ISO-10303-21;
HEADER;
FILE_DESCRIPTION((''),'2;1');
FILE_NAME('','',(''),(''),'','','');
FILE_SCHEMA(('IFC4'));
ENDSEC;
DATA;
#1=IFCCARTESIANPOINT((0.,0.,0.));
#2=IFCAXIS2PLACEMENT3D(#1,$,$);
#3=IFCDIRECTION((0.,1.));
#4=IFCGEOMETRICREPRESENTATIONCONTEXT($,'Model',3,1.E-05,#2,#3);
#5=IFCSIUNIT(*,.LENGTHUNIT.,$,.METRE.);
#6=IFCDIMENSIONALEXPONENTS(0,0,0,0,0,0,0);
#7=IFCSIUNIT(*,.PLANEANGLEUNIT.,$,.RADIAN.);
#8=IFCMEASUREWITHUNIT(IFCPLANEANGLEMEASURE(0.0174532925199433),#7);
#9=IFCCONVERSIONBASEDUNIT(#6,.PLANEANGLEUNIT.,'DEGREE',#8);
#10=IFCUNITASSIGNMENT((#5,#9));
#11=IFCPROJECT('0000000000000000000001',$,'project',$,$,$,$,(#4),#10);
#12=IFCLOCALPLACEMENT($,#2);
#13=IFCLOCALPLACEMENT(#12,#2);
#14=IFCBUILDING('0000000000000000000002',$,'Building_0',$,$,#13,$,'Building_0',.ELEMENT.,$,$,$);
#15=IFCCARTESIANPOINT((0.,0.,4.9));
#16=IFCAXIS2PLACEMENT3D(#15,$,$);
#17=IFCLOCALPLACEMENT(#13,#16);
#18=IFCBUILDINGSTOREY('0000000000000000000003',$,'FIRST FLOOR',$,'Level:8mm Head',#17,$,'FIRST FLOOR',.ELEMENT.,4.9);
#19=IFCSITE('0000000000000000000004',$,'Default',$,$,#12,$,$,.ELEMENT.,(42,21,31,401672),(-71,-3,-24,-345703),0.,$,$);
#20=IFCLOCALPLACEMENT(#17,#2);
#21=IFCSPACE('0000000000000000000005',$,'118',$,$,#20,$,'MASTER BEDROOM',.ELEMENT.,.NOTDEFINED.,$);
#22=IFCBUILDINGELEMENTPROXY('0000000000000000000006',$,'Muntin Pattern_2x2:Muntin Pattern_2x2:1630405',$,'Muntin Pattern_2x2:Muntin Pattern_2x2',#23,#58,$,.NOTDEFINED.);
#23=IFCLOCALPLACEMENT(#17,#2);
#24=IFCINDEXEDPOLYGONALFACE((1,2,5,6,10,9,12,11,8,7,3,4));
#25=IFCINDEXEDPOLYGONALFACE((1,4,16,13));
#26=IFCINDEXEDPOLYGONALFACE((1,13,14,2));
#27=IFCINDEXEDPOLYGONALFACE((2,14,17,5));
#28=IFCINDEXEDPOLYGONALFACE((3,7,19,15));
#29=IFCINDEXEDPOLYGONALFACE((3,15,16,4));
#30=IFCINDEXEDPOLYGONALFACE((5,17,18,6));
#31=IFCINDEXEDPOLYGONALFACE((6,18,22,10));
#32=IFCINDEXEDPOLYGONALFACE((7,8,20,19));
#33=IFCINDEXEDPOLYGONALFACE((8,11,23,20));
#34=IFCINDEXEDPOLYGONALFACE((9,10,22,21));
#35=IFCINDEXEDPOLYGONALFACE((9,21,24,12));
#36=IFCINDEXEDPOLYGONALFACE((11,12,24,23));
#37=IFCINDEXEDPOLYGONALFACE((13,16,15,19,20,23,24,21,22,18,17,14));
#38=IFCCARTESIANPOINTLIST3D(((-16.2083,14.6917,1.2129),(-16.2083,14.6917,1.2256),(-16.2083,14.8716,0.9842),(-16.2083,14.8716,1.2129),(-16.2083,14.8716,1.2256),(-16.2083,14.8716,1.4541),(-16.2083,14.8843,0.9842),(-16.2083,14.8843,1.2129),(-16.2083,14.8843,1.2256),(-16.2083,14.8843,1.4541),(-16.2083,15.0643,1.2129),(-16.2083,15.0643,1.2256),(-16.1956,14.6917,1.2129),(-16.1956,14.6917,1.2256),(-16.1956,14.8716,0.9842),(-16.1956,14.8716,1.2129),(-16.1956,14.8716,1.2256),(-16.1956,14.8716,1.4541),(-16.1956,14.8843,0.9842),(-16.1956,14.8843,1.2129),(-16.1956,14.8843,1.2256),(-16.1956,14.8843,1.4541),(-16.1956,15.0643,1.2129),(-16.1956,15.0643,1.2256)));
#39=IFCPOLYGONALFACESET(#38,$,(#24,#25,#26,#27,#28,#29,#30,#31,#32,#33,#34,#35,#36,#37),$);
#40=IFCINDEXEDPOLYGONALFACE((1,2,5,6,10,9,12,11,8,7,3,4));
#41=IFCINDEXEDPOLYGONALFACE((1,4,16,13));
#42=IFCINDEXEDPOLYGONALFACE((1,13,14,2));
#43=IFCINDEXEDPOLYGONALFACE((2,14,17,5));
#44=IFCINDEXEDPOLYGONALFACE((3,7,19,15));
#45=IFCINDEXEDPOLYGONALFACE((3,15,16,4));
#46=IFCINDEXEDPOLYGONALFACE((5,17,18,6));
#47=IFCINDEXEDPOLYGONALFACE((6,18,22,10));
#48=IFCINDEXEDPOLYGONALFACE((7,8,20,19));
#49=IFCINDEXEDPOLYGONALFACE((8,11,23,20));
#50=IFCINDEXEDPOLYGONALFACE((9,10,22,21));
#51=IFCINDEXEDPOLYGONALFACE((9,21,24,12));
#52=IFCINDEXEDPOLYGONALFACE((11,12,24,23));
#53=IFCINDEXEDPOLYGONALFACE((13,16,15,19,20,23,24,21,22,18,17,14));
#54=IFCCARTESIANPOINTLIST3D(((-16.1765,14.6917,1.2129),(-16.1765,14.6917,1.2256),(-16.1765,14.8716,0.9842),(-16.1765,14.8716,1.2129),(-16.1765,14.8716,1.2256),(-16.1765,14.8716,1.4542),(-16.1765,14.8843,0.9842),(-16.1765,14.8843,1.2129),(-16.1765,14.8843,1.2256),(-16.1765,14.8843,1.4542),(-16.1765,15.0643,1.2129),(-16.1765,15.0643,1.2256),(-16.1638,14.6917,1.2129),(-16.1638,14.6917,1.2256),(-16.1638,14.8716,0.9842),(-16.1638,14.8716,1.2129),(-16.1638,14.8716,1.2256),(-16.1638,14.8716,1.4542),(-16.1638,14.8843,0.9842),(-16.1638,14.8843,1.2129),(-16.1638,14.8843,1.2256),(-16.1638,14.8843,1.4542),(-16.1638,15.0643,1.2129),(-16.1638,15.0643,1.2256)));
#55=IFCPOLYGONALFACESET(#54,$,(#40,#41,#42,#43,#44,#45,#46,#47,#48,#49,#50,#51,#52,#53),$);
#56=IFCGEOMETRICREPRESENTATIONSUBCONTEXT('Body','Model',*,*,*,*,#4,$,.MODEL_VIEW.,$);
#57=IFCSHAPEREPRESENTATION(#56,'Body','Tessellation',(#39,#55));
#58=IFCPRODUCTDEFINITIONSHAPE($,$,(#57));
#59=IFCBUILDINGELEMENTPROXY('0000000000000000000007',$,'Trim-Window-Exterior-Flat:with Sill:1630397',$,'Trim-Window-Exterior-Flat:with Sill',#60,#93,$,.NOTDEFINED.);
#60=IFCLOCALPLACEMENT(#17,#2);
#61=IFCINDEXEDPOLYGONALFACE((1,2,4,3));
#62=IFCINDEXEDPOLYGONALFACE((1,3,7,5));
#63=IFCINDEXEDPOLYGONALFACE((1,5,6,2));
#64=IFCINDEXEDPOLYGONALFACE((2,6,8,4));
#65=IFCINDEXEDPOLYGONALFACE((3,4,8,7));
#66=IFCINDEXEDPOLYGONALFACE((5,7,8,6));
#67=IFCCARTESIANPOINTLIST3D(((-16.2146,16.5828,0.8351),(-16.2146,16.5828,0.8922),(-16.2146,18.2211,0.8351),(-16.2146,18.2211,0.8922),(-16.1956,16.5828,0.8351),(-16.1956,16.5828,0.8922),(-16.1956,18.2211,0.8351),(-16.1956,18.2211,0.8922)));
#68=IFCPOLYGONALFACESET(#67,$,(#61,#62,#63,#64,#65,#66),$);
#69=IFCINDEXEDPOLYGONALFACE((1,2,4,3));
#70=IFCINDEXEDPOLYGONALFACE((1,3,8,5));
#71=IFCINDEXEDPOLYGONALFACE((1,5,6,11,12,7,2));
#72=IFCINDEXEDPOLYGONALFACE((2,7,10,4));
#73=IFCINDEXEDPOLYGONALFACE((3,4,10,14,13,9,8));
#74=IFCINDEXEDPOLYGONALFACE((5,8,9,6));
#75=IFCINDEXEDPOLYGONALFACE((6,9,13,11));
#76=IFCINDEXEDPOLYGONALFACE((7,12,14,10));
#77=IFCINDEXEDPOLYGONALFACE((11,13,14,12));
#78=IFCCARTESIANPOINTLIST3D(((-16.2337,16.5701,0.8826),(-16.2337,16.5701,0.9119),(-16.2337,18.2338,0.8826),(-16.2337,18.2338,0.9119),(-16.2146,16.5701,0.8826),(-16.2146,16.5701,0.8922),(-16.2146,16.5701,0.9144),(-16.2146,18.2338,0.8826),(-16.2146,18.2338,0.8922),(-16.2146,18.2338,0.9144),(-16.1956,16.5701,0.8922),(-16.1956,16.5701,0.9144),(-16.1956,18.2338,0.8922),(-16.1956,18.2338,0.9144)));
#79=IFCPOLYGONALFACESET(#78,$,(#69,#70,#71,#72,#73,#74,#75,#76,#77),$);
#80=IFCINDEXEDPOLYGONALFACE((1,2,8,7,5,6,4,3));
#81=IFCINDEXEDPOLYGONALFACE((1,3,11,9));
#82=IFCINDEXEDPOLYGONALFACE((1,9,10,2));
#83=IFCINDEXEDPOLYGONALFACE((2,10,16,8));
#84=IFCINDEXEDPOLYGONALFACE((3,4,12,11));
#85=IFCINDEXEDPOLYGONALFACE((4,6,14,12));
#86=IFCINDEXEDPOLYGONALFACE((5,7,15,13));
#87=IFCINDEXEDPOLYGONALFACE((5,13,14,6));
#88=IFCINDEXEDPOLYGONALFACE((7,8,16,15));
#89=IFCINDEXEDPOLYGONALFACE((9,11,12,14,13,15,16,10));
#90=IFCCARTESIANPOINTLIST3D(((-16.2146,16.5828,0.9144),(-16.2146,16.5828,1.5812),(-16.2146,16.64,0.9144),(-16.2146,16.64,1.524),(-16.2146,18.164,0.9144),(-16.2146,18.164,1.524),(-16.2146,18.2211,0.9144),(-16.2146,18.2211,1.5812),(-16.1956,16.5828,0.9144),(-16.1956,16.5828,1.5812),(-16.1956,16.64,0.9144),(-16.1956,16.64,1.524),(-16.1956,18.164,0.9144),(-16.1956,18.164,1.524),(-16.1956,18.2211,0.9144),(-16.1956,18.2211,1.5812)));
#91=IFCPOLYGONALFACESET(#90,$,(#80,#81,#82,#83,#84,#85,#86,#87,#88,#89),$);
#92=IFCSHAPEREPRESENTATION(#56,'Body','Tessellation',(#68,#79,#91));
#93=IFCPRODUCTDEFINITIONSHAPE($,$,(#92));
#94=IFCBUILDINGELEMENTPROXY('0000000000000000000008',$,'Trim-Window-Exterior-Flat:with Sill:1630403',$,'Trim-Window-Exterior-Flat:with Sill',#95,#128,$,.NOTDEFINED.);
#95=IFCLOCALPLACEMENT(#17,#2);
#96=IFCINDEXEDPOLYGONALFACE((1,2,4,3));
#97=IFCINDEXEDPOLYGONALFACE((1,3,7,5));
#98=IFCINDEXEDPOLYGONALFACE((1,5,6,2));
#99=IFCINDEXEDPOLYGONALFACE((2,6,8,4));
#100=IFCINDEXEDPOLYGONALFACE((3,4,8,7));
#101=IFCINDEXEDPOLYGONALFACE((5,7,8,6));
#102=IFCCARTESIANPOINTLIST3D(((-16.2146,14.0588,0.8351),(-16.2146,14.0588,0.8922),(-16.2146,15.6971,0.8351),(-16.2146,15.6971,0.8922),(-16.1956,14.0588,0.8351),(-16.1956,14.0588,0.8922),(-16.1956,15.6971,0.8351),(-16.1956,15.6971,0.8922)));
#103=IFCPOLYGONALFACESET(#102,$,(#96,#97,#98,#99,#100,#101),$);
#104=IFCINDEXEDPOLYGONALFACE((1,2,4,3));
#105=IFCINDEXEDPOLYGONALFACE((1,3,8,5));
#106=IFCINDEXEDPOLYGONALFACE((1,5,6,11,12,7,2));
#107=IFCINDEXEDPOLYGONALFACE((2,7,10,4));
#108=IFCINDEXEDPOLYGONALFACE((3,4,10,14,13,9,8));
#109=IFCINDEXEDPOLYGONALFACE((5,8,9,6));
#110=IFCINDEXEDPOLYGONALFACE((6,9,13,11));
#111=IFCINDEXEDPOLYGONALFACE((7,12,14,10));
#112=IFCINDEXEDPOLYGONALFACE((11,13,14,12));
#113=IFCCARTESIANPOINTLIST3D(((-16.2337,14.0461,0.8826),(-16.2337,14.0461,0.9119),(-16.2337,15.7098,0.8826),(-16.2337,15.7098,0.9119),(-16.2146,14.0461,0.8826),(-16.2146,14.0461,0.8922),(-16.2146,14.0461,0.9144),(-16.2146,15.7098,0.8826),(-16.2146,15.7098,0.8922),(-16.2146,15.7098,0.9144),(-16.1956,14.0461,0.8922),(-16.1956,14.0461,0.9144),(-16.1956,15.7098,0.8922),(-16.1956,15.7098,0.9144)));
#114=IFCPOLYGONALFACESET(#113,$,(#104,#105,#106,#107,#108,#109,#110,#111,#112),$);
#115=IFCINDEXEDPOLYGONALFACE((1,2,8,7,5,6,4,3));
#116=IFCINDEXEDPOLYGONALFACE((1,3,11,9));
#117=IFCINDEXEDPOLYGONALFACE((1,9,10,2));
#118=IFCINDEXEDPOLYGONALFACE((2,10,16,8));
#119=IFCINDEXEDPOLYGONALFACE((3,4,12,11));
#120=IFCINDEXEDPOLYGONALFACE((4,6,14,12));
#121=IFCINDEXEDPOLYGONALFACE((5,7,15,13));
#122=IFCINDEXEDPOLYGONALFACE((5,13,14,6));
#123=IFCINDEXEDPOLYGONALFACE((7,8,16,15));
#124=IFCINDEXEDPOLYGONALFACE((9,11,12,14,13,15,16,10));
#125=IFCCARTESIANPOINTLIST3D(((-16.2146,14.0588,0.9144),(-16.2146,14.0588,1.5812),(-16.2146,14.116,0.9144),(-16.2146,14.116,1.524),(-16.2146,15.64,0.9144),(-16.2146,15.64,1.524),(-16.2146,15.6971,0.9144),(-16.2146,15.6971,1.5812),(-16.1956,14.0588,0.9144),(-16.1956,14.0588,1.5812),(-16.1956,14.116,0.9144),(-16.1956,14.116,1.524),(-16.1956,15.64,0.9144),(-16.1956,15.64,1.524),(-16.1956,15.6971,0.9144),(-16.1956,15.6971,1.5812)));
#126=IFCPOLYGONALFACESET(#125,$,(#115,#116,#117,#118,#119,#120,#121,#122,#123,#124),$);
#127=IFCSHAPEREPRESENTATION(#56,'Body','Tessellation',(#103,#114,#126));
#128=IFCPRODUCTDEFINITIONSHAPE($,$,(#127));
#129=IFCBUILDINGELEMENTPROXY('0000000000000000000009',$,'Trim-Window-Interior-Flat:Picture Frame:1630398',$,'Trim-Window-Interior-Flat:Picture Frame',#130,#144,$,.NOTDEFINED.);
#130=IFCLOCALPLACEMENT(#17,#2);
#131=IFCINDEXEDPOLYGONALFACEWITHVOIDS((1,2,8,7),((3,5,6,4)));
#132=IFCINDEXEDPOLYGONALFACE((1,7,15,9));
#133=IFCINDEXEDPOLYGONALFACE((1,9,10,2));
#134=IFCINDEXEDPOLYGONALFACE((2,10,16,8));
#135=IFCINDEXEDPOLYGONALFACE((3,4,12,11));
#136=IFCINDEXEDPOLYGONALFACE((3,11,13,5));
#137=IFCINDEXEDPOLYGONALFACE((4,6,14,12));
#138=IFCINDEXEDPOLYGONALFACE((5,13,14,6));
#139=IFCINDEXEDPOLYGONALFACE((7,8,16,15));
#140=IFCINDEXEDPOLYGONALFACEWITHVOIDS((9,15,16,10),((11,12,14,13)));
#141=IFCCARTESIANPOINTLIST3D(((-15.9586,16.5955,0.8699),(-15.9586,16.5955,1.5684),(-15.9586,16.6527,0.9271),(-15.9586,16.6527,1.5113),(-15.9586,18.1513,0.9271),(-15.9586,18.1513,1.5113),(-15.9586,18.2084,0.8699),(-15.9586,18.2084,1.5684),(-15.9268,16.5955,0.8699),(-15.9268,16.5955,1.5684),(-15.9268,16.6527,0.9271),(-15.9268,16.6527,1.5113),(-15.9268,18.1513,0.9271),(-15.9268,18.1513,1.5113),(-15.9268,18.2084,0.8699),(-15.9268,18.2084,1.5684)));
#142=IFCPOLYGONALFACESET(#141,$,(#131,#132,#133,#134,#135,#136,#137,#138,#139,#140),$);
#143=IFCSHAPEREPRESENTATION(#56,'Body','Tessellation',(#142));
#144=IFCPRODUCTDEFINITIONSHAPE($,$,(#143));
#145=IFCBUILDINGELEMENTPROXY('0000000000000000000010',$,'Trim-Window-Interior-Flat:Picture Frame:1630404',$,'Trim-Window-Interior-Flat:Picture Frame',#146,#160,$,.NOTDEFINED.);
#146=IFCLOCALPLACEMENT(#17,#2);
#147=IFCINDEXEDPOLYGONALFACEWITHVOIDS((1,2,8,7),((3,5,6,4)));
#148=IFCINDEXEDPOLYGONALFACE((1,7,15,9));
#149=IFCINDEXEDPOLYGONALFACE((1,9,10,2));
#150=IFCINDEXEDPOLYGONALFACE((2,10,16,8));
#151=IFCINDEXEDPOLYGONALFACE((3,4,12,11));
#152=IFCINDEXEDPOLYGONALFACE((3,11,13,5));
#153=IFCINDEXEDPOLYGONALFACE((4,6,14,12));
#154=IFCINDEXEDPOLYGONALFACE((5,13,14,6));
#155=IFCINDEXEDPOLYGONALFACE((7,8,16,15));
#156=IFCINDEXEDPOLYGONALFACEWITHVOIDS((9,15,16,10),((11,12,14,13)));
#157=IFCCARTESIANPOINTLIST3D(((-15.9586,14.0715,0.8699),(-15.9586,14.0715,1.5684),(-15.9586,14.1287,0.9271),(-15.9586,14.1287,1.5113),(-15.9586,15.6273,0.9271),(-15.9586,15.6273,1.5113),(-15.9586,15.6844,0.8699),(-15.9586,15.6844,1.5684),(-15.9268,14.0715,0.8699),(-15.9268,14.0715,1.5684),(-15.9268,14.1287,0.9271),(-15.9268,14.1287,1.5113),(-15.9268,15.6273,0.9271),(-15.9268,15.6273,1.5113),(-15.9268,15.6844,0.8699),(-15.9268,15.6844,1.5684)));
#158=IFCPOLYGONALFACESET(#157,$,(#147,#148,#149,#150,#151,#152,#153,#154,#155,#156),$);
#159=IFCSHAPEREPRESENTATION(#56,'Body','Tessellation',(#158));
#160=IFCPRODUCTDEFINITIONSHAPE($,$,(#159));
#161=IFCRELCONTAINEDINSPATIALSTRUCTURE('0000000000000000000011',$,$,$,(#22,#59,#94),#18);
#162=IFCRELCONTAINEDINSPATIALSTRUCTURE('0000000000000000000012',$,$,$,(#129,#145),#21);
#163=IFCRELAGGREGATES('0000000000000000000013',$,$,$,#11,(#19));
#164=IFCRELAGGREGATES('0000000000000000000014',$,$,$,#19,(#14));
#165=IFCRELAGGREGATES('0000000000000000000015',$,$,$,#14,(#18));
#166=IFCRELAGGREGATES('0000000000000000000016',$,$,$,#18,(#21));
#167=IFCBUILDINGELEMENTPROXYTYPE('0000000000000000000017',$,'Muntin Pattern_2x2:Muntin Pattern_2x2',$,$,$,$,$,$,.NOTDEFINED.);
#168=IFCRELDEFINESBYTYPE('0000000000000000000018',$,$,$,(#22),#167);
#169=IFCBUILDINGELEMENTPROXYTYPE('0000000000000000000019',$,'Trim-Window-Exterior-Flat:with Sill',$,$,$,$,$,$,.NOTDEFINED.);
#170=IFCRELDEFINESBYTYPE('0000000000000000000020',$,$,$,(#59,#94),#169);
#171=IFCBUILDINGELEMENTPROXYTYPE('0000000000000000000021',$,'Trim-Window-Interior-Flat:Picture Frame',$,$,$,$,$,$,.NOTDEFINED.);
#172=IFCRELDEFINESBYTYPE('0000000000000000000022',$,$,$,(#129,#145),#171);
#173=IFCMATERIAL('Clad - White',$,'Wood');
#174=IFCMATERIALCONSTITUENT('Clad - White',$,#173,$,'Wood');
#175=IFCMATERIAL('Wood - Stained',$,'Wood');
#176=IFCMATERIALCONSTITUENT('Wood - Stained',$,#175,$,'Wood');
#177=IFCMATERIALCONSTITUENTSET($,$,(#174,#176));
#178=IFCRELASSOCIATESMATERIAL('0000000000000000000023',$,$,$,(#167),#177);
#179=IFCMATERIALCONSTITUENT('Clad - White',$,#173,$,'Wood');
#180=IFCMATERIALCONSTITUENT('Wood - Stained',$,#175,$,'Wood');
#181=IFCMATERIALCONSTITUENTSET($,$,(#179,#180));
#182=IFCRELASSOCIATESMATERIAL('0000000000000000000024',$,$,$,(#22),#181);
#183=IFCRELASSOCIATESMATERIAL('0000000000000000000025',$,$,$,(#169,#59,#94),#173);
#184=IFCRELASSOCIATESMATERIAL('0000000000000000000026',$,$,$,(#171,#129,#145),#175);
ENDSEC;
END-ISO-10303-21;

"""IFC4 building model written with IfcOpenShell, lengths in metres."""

from ifc_helpers import new_model, entity, si_unit, converted_unit, direction, frame, origin, place, context, subcontext, project, spatial, indexed_curve, outline, extrude, source, transform, mapped, material, constituent, constituent_set, type_object, type_shapes, element, save


model = new_model("IFC4")

# Units and contexts
model_context = context("Model", 3, precision=1e-05, world=origin(), true_north=direction((0.0, 1.0)))
body_context = subcontext(model_context, "Body", "Model", "MODEL_VIEW")
ifc_project = project(units=[si_unit("LENGTHUNIT", "METRE"), converted_unit("PLANEANGLEUNIT", "DEGREE", entity("IfcPlaneAngleMeasure", 0.0174532925199433), si_unit("PLANEANGLEUNIT", "RADIAN"), dimensions=[0, 0, 0, 0, 0, 0, 0])], contexts=[model_context])

# Site, building, storey
site_placement = place(None, origin())
site = spatial("IfcSite", under=ifc_project, at=site_placement, Name="Default", CompositionType="ELEMENT", RefLatitude=(42, 21, 31, 401672), RefLongitude=(-71, -3, -24, -345703), RefElevation=0.0)
building_placement = place(site_placement, origin())
building = spatial("IfcBuilding", under=site, at=building_placement, Name="Building_0", LongName="Building_0", CompositionType="ELEMENT")
storey_placement = place(building_placement, frame((0.0, 0.0, 4.9)))
storey = spatial("IfcBuildingStorey", under=building, at=storey_placement, Name="FIRST FLOOR", ObjectType="Level:8mm Head", LongName="FIRST FLOOR", CompositionType="ELEMENT", Elevation=4.9)

# Shared definitions
ifc_material_1 = material(Name="Clad - White", Category="Wood")

# Shared definitions
space_placement = place(storey_placement, origin())
space = spatial("IfcSpace", under=storey, at=space_placement, Name="118", LongName="MASTER BEDROOM", CompositionType="ELEMENT", PredefinedType="NOTDEFINED")

# Building element proxies
ifc_material_2 = material(Name="Wood - Stained", Category="Wood")
ifc_constituent_1 = constituent(ifc_material_1, Name="Clad - White", Category="Wood")
ifc_constituent_2 = constituent(ifc_material_2, Name="Wood - Stained", Category="Wood")
ifc_constituent_set_1 = constituent_set(constituents=[ifc_constituent_1, ifc_constituent_2])
building_element_proxy_type_1 = type_object("IfcBuildingElementProxyType", Name="Muntin Pattern_2x2:Muntin Pattern_2x2", PredefinedType="NOTDEFINED", material=ifc_constituent_set_1)
shared_shape_1 = source(origin(), body_context, "Body", "SweptSolid", [
    extrude(outline(indexed_curve([(0.0064, -0.0064), (0.2349, -0.0064), (0.2349, 0.0063), (0.0064, 0.0063), (0.0064, 0.1863), (-0.0063, 0.1863), (-0.0063, 0.0063), (-0.235, 0.0063), (-0.235, -0.0064), (-0.0063, -0.0064), (-0.0063, -0.1863), (0.0064, -0.1863), (0.0064, -0.0064)], self_intersect=False)), frame((0.0, -0.0222, 0.2349), z_axis=(0.0, 1.0, 0.0), x_axis=(0.0, 0.0, 1.0)), (0.0, 0.0, 1.0), 0.0127),
    extrude(outline(indexed_curve([(0.0064, -0.0064), (0.235, -0.0064), (0.235, 0.0063), (0.0064, 0.0063), (0.0064, 0.1863), (-0.0063, 0.1863), (-0.0063, 0.0063), (-0.235, 0.0063), (-0.235, -0.0064), (-0.0063, -0.0064), (-0.0063, -0.1863), (0.0064, -0.1863), (0.0064, -0.0064)], self_intersect=False)), frame((0.0, 0.0095, 0.235), z_axis=(0.0, 1.0, 0.0), x_axis=(0.0, 0.0, 1.0)), (0.0, 0.0, 1.0), 0.0127),
])
type_shapes(building_element_proxy_type_1, [shared_shape_1])
ifc_constituent_3 = constituent(ifc_material_1, Name="Clad - White", Category="Wood")
ifc_constituent_4 = constituent(ifc_material_2, Name="Wood - Stained", Category="Wood")
ifc_constituent_set_2 = constituent_set(constituents=[ifc_constituent_3, ifc_constituent_4])
proxy_1_placement = place(storey_placement, frame((-16.1861, 14.878, 0.9842), z_axis=(0.0, 0.0, 1.0), x_axis=(0.0, -1.0, 0.0)))
element("IfcBuildingElementProxy", 1, at=proxy_1_placement, inside=storey, type_object=building_element_proxy_type_1, material=ifc_constituent_set_2, Name="Muntin Pattern_2x2:Muntin Pattern_2x2:1630405", ObjectType="Muntin Pattern_2x2:Muntin Pattern_2x2", PredefinedType="NOTDEFINED", context=body_context, shape_type="MappedRepresentation", body=[
    mapped(shared_shape_1, transform((0.0, 0.0, 0.0), scale=1.0)),
])
building_element_proxy_type_2 = type_object("IfcBuildingElementProxyType", Name="Trim-Window-Exterior-Flat:with Sill", PredefinedType="NOTDEFINED", material=ifc_material_1)
shared_shape_2 = source(origin(), body_context, "Body", "SweptSolid", [
    extrude(outline(indexed_curve([(-0.8191, -0.0286), (0.8191, -0.0286), (0.8191, 0.0286), (-0.8191, 0.0286), (-0.8191, -0.0286)], self_intersect=False)), frame((0.0, -0.6604, 0.0), z_axis=(0.0, 0.0, 1.0), x_axis=(-1.0, 0.0, 0.0)), (0.0, 0.0, 1.0), 0.0191),
    extrude(outline(indexed_curve([(-0.019, -0.016), (0.0, -0.016), (0.0, -0.0064), (0.019, -0.0064), (0.019, 0.0158), (0.0, 0.0158), (-0.019, 0.0133), (-0.019, -0.016)], self_intersect=False)), frame((-0.8318, -0.6254, 0.019), z_axis=(1.0, 0.0, 0.0), x_axis=(0.0, 0.0, -1.0)), (0.0, 0.0, 1.0), 1.6637),
    extrude(outline(indexed_curve([(-0.3477, -0.8192), (0.3191, -0.8192), (0.3191, -0.762), (-0.2905, -0.762), (-0.2905, 0.762), (0.3191, 0.762), (0.3191, 0.8191), (-0.3477, 0.8191), (-0.3477, -0.8192)], self_intersect=False)), frame((0.0, -0.2905, 0.0), z_axis=(0.0, 0.0, 1.0), x_axis=(0.0, -1.0, 0.0)), (0.0, 0.0, 1.0), 0.0191),
])
type_shapes(building_element_proxy_type_2, [shared_shape_2])
for number, where, z_axis, x_axis, name in (
    (2, (-16.1956, 17.402, 1.524), (-1.0, 0.0, 0.0), (0.0, -1.0, 0.0), "Trim-Window-Exterior-Flat:with Sill:1630397"),
    (3, (-16.1956, 14.878, 1.524), (-1.0, 0.0, 0.0), (0.0, -1.0, 0.0), "Trim-Window-Exterior-Flat:with Sill:1630403"),
):
    element("IfcBuildingElementProxy", number, at=place(storey_placement, frame(where, z_axis=z_axis, x_axis=x_axis)), inside=storey, type_object=building_element_proxy_type_2, material=ifc_material_1, Name=name, ObjectType="Trim-Window-Exterior-Flat:with Sill", PredefinedType="NOTDEFINED", context=body_context, shape_type="MappedRepresentation", body=[
        mapped(shared_shape_2, transform((0.0, 0.0, 0.0), scale=1.0)),
    ])
building_element_proxy_type_3 = type_object("IfcBuildingElementProxyType", Name="Trim-Window-Interior-Flat:Picture Frame", PredefinedType="NOTDEFINED", material=ifc_material_2)
shared_shape_3 = source(origin(), body_context, "Body", "SweptSolid", [
    extrude(outline(indexed_curve([(-0.8064, -0.3492), (0.8064, -0.3492), (0.8064, 0.3492), (-0.8064, 0.3492), (-0.8064, -0.3492)], self_intersect=False), holes=[indexed_curve([(-0.7493, -0.2921), (-0.7493, 0.2921), (0.7493, 0.2921), (0.7493, -0.2921), (-0.7493, -0.2921)], self_intersect=False)]), frame((0.0, -0.3048, 0.0), z_axis=(0.0, 0.0, 1.0), x_axis=(-1.0, 0.0, 0.0)), (0.0, 0.0, 1.0), 0.0318),
])
type_shapes(building_element_proxy_type_3, [shared_shape_3])
for number, where, z_axis, x_axis, name in (
    (4, (-15.9586, 17.402, 1.524), (1.0, 0.0, 0.0), (0.0, 1.0, 0.0), "Trim-Window-Interior-Flat:Picture Frame:1630398"),
    (5, (-15.9586, 14.878, 1.524), (1.0, 0.0, 0.0), (0.0, 1.0, 0.0), "Trim-Window-Interior-Flat:Picture Frame:1630404"),
):
    element("IfcBuildingElementProxy", number, at=place(space_placement, frame(where, z_axis=z_axis, x_axis=x_axis)), inside=space, type_object=building_element_proxy_type_3, material=ifc_material_2, Name=name, ObjectType="Trim-Window-Interior-Flat:Picture Frame", PredefinedType="NOTDEFINED", context=body_context, shape_type="MappedRepresentation", body=[
        mapped(shared_shape_3, transform((0.0, 0.0, 0.0), scale=1.0)),
    ])

save(model, "model.ifc")
